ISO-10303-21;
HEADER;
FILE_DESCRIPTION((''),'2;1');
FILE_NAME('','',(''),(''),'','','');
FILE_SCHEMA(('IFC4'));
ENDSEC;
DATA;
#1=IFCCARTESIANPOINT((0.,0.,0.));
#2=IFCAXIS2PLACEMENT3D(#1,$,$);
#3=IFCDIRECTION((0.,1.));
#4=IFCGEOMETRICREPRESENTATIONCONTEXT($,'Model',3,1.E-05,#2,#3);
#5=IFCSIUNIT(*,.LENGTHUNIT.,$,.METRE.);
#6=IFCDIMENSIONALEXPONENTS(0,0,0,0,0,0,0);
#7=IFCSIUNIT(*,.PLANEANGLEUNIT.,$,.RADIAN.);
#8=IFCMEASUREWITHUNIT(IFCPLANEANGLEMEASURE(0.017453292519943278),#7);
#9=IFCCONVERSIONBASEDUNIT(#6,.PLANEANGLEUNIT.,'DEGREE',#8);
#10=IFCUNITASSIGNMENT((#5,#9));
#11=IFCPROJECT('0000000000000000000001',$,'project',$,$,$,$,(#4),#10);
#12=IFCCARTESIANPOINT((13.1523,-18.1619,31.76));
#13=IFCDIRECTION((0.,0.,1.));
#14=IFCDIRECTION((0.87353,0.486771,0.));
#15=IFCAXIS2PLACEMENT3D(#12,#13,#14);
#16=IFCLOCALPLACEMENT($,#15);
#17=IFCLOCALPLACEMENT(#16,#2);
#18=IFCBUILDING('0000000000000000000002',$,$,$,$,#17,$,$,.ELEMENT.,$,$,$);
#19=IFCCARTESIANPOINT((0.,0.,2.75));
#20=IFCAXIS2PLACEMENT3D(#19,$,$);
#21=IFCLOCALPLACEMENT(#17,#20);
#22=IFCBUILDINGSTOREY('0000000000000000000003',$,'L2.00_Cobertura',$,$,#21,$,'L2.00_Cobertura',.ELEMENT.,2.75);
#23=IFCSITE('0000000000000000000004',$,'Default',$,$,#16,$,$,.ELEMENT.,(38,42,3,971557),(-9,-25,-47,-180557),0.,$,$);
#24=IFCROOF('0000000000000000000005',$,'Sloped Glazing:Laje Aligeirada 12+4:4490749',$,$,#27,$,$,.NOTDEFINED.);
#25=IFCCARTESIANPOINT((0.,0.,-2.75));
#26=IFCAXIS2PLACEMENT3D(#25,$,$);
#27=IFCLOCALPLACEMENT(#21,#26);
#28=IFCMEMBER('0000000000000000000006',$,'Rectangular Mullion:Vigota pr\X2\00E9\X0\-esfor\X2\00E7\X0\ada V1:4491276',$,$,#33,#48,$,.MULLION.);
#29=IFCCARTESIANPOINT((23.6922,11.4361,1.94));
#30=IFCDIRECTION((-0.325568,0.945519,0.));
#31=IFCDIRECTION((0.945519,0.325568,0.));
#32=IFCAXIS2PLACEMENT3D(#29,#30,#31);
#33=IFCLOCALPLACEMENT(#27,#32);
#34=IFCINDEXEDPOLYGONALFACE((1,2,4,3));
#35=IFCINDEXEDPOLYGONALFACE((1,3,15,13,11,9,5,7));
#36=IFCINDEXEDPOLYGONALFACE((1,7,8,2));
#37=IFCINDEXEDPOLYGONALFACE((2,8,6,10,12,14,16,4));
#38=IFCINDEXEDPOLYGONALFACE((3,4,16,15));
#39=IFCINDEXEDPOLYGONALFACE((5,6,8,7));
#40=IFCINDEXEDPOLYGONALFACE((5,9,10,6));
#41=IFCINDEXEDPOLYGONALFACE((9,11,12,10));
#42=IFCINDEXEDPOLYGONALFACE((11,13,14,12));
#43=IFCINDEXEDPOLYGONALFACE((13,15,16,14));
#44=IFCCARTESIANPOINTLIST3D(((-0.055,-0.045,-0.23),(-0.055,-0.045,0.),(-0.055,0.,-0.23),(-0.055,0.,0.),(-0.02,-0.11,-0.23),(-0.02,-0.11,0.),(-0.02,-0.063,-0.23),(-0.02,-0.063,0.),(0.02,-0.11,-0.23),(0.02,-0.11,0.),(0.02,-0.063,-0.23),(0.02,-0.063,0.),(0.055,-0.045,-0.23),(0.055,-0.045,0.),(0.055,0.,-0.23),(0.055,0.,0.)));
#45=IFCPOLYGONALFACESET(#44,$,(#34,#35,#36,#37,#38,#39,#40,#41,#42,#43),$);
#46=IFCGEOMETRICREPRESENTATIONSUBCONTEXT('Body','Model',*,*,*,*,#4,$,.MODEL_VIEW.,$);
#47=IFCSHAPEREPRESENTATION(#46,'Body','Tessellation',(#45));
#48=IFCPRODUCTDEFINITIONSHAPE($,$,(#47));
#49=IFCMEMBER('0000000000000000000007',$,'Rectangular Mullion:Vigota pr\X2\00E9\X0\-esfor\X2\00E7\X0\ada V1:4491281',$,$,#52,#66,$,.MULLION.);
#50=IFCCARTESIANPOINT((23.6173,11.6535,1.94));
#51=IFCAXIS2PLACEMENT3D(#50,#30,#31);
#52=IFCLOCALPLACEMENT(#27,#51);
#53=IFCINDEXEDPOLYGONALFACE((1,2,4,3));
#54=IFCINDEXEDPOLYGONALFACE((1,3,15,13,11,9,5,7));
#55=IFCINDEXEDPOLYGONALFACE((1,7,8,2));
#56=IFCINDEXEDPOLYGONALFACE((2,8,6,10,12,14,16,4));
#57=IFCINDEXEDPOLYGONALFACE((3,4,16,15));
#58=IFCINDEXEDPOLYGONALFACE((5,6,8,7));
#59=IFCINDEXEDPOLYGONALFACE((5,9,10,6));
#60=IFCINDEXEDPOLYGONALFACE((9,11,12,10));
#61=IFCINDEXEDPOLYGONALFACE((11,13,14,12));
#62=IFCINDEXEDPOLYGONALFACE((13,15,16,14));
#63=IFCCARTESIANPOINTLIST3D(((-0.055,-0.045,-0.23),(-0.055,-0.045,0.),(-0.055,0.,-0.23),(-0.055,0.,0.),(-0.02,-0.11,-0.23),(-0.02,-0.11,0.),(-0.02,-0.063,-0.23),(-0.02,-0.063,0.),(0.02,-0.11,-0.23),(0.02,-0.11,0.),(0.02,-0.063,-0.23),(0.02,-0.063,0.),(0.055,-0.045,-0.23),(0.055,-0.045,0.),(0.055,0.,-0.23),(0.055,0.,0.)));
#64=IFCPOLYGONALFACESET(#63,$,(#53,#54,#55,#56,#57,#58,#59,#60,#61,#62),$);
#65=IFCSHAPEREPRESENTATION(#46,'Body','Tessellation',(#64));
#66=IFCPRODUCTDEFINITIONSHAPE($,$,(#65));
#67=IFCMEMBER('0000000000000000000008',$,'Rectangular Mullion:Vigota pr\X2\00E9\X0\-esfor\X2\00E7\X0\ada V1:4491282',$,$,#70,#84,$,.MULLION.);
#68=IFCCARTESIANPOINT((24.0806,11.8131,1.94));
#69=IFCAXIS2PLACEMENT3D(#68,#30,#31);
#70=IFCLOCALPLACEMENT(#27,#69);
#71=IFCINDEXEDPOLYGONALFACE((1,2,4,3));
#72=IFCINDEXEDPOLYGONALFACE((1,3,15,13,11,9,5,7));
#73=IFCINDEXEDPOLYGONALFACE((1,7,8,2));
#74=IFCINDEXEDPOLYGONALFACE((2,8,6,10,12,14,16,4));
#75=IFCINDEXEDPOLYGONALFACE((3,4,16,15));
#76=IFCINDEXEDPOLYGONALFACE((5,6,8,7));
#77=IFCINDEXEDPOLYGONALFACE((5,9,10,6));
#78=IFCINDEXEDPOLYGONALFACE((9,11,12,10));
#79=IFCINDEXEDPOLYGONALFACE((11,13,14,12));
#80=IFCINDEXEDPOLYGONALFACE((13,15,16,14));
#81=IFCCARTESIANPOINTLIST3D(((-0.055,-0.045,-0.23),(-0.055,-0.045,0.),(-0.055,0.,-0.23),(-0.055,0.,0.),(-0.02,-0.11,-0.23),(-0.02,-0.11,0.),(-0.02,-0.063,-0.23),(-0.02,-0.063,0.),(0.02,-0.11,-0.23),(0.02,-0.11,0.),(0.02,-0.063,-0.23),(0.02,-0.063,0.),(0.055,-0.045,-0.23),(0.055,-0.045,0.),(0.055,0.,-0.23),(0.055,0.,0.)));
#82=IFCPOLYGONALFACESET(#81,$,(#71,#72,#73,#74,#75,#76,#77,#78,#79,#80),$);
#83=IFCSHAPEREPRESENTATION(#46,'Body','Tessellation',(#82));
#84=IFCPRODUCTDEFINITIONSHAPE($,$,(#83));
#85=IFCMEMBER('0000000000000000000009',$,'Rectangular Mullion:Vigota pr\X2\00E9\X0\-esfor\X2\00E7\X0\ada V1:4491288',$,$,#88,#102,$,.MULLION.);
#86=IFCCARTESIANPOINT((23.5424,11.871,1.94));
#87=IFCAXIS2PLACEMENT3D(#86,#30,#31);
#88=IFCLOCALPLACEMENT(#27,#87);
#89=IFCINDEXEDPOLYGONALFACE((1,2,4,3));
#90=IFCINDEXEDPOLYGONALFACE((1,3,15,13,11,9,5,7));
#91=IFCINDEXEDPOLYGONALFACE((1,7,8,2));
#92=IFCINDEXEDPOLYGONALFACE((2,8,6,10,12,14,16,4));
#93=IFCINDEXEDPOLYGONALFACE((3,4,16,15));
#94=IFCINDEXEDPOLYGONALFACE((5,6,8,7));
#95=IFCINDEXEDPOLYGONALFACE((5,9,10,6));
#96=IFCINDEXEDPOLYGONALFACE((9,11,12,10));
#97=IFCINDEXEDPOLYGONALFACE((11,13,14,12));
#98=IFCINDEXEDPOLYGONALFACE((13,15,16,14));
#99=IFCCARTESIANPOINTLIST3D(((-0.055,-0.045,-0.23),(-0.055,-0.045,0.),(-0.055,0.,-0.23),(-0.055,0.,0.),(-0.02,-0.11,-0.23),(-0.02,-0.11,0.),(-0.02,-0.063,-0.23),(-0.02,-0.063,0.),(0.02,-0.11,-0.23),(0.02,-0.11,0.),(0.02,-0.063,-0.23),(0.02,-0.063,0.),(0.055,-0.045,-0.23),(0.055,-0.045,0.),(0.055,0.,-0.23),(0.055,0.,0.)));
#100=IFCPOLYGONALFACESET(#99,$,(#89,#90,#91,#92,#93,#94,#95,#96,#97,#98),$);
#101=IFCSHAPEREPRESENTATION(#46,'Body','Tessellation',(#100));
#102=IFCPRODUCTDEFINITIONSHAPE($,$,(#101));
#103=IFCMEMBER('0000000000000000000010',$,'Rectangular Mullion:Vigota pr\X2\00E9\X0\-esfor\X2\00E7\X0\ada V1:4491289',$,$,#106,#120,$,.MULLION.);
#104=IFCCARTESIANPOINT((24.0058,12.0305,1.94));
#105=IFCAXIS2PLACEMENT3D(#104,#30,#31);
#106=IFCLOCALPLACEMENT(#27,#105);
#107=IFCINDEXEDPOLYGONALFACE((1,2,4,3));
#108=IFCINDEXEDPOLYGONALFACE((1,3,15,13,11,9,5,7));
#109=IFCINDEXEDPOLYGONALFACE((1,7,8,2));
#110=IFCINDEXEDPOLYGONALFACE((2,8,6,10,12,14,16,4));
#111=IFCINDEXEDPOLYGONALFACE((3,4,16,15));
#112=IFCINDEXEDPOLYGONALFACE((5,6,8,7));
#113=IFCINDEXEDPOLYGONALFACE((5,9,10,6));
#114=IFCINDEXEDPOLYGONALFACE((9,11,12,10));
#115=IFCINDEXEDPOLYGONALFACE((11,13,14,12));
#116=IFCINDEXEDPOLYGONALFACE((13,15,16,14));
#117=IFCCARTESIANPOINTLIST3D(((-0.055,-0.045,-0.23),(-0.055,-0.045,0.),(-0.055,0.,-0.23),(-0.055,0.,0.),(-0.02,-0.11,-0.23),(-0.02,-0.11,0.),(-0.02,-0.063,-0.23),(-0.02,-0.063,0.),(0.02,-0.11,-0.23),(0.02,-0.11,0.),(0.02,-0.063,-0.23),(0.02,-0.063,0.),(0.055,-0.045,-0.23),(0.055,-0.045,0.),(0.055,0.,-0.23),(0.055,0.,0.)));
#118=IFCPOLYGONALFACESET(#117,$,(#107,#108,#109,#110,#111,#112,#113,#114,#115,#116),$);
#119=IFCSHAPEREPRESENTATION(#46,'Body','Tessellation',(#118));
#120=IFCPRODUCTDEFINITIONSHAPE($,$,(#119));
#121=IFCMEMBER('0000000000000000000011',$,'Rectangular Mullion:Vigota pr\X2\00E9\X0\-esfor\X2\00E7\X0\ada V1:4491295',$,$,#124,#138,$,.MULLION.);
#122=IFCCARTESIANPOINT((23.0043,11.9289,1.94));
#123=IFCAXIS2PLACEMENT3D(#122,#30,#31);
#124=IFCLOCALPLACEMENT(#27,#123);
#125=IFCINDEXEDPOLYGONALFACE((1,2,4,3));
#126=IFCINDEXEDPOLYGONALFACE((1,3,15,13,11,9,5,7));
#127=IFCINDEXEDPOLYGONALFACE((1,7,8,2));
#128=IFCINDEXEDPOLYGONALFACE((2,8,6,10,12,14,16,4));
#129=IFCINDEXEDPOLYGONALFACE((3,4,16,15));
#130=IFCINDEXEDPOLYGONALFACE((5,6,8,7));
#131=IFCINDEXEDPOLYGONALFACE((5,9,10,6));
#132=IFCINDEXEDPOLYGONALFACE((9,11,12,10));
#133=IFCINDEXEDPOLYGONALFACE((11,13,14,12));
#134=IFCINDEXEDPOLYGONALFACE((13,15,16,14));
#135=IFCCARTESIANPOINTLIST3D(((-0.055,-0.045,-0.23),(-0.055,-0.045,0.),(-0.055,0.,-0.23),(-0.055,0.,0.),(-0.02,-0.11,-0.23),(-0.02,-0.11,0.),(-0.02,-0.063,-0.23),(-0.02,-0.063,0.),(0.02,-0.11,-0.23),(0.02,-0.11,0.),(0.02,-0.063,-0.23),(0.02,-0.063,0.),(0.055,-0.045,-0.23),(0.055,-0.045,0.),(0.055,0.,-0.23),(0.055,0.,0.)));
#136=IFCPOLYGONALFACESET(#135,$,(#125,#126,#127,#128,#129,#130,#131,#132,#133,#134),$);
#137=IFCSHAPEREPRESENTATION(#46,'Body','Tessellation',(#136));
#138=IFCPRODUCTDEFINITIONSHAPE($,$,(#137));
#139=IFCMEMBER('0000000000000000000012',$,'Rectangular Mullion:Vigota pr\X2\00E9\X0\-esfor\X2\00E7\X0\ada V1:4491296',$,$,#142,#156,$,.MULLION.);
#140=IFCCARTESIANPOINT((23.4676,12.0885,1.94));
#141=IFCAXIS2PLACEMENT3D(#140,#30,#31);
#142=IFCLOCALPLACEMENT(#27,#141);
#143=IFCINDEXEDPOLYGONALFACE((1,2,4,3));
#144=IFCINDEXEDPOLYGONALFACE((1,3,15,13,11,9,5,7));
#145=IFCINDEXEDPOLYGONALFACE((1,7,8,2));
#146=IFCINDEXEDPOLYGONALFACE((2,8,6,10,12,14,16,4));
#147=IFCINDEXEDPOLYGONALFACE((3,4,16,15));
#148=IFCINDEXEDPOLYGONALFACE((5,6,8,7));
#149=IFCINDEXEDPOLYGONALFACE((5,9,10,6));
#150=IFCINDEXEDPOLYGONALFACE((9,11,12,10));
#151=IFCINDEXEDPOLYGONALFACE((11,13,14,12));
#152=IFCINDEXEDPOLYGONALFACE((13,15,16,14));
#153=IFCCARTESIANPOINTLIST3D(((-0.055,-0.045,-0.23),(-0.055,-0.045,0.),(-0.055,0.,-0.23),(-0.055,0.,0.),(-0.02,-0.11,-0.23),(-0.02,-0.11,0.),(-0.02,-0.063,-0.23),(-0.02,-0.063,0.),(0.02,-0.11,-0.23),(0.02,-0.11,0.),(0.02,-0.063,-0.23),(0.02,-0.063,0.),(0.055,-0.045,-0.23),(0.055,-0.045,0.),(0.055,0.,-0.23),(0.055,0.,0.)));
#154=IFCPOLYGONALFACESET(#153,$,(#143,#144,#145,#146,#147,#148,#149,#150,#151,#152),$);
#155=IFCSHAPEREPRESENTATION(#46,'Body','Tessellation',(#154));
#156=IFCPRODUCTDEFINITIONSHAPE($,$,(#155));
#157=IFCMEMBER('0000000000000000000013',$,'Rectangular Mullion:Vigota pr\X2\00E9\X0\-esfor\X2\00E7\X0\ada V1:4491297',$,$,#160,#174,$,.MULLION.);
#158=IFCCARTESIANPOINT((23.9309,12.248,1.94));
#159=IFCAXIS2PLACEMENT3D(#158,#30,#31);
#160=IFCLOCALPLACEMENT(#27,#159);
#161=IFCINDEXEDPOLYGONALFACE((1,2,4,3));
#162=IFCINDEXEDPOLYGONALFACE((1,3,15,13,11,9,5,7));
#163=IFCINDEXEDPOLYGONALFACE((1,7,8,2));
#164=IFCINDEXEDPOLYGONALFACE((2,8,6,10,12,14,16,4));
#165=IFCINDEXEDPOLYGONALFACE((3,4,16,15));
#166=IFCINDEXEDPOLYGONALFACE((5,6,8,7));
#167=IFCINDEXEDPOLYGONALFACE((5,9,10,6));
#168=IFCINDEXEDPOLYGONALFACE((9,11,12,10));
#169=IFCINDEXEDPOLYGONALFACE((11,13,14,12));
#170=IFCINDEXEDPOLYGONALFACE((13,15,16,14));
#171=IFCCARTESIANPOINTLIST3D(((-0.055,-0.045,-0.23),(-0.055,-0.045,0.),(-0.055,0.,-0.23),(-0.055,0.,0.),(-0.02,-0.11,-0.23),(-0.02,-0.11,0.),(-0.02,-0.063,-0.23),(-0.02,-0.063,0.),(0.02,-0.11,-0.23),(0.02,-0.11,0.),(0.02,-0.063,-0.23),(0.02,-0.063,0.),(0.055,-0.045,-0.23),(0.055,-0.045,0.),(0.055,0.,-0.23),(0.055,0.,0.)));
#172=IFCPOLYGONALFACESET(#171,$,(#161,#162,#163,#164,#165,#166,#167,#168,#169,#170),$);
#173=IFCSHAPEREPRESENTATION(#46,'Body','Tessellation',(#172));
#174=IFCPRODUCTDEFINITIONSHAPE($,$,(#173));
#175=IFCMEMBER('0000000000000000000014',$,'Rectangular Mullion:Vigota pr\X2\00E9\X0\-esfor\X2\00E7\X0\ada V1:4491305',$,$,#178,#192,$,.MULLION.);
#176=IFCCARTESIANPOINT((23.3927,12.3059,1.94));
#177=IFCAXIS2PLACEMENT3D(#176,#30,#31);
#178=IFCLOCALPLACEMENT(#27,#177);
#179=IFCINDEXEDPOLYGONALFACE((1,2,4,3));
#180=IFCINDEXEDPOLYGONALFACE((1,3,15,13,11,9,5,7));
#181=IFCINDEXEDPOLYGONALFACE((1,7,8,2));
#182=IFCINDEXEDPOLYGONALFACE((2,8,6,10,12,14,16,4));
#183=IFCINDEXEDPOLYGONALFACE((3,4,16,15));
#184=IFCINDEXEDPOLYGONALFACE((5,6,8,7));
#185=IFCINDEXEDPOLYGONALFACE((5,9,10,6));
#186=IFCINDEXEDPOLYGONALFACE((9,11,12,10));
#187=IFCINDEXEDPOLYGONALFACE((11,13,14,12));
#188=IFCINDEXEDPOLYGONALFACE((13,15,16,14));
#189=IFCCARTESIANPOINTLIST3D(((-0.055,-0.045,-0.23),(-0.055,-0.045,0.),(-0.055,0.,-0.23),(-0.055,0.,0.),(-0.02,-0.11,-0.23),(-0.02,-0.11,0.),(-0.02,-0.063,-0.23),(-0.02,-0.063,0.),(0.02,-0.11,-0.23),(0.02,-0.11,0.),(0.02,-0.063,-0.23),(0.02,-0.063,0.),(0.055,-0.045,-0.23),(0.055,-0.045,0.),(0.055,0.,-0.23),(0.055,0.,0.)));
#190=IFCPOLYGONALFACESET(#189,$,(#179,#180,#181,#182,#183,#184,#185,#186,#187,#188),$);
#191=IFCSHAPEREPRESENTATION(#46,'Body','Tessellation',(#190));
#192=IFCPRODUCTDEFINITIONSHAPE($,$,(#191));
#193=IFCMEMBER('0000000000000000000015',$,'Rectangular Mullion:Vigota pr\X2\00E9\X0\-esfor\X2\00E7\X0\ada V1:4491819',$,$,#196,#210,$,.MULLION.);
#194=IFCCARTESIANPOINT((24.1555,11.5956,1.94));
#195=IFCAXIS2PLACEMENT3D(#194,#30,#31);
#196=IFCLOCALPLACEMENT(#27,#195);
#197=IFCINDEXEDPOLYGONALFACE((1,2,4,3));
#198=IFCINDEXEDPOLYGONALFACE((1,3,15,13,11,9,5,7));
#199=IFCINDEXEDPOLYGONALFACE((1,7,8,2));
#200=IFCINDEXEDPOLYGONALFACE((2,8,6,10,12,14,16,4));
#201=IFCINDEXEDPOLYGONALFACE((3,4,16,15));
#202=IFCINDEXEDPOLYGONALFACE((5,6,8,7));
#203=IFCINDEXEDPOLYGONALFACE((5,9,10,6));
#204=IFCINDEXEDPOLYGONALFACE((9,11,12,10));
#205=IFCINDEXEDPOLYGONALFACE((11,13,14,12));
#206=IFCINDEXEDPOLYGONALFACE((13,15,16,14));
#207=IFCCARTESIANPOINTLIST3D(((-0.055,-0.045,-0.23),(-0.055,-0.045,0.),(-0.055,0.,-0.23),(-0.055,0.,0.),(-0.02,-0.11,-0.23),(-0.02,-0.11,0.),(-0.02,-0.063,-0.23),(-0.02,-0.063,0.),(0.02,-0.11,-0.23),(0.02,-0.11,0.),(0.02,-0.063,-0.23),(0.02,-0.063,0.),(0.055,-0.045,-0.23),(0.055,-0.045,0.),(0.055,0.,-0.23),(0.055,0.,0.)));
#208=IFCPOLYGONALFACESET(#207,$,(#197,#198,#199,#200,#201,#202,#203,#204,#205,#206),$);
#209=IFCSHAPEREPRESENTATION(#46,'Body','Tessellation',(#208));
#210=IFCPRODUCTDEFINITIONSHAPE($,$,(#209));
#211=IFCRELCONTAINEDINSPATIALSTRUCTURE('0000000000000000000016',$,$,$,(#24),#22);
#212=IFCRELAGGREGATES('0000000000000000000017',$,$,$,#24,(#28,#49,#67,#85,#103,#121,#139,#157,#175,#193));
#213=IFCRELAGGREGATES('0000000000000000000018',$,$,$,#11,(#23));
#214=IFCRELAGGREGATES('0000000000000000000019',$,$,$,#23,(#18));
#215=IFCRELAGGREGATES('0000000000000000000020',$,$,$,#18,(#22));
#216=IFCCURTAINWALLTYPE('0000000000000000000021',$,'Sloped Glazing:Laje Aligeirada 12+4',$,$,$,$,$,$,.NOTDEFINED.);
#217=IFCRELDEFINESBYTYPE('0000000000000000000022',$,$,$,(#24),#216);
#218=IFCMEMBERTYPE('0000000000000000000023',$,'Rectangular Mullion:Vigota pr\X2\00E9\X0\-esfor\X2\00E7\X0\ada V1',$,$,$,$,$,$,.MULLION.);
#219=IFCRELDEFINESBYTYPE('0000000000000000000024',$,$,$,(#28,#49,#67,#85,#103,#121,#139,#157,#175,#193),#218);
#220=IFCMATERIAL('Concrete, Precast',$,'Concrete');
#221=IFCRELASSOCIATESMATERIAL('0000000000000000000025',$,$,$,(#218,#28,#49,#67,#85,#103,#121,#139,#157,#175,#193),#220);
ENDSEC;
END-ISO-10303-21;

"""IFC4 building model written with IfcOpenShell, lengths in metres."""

from ifc_helpers import new_model, entity, si_unit, converted_unit, direction, frame, origin, place, context, subcontext, project, spatial, indexed_curve, outline, extrude, source, transform, mapped, material, type_object, type_shapes, element, aggregate, save


model = new_model("IFC4")

# Units and contexts
model_context = context("Model", 3, precision=1e-05, world=origin(), true_north=direction((0.0, 1.0)))
body_context = subcontext(model_context, "Body", "Model", "MODEL_VIEW")
ifc_project = project(units=[si_unit("LENGTHUNIT", "METRE"), converted_unit("PLANEANGLEUNIT", "DEGREE", entity("IfcPlaneAngleMeasure", 0.017453292519943278), si_unit("PLANEANGLEUNIT", "RADIAN"), dimensions=[0, 0, 0, 0, 0, 0, 0])], contexts=[model_context])

# Site, building, storey
site_placement = place(None, frame((13.1523, -18.1619, 31.76), z_axis=(0.0, 0.0, 1.0), x_axis=(0.87353, 0.486771, 0.0)))
site = spatial("IfcSite", under=ifc_project, at=site_placement, Name="Default", CompositionType="ELEMENT", RefLatitude=(38, 42, 3, 971557), RefLongitude=(-9, -25, -47, -180557), RefElevation=0.0)
building_placement = place(site_placement, origin())
building = spatial("IfcBuilding", under=site, at=building_placement, CompositionType="ELEMENT")
storey_placement = place(building_placement, frame((0.0, 0.0, 2.75)))
storey = spatial("IfcBuildingStorey", under=building, at=storey_placement, Name="L2.00_Cobertura", LongName="L2.00_Cobertura", CompositionType="ELEMENT", Elevation=2.75)

# Roof, members
curtain_wall_type = type_object("IfcCurtainWallType", Name="Sloped Glazing:Laje Aligeirada 12+4", PredefinedType="NOTDEFINED")
roof_placement = place(storey_placement, frame((0.0, 0.0, -2.75)))
roof = element("IfcRoof", 1, at=roof_placement, inside=storey, type_object=curtain_wall_type, Name="Sloped Glazing:Laje Aligeirada 12+4:4490749", PredefinedType="NOTDEFINED")
ifc_material_1 = material(Name="Concrete, Precast", Category="Concrete")
member_type_1 = type_object("IfcMemberType", Name="Rectangular Mullion:Vigota pré-esforçada V1", PredefinedType="MULLION", material=ifc_material_1)
shared_shape_1 = source(origin(), body_context, "Body", "SweptSolid", [
    extrude(outline(indexed_curve([(-0.055, -0.0545), (0.055, -0.0545), (0.055, -0.0095), (0.02, 0.0085), (0.02, 0.0555), (-0.02, 0.0555), (-0.02, 0.0085), (-0.055, -0.0095), (-0.055, -0.0545)], self_intersect=False)), frame((0.0, -0.0545, -0.23), z_axis=(0.0, 0.0, 1.0), x_axis=(-1.0, 0.0, 0.0)), (0.0, 0.0, 1.0), 0.23),
])
type_shapes(member_type_1, [shared_shape_1])
member_1_placement = place(roof_placement, frame((23.6922, 11.4361, 1.94), z_axis=(-0.325568, 0.945519, 0.0), x_axis=(0.945519, 0.325568, 0.0)))
member_1 = element("IfcMember", 2, at=member_1_placement, type_object=member_type_1, material=ifc_material_1, Name="Rectangular Mullion:Vigota pré-esforçada V1:4491276", PredefinedType="MULLION", context=body_context, shape_type="MappedRepresentation", body=[
    mapped(shared_shape_1, transform((0.0, 0.0, 0.0), scale=1.0)),
])
member_2_placement = place(roof_placement, frame((23.6173, 11.6535, 1.94), z_axis=(-0.325568, 0.945519, 0.0), x_axis=(0.945519, 0.325568, 0.0)))
member_2 = element("IfcMember", 3, at=member_2_placement, type_object=member_type_1, material=ifc_material_1, Name="Rectangular Mullion:Vigota pré-esforçada V1:4491281", PredefinedType="MULLION", context=body_context, shape_type="MappedRepresentation", body=[
    mapped(shared_shape_1, transform((0.0, 0.0, 0.0), scale=1.0)),
])
member_3_placement = place(roof_placement, frame((24.0806, 11.8131, 1.94), z_axis=(-0.325568, 0.945519, 0.0), x_axis=(0.945519, 0.325568, 0.0)))
member_3 = element("IfcMember", 4, at=member_3_placement, type_object=member_type_1, material=ifc_material_1, Name="Rectangular Mullion:Vigota pré-esforçada V1:4491282", PredefinedType="MULLION", context=body_context, shape_type="MappedRepresentation", body=[
    mapped(shared_shape_1, transform((0.0, 0.0, 0.0), scale=1.0)),
])
member_4_placement = place(roof_placement, frame((23.5424, 11.871, 1.94), z_axis=(-0.325568, 0.945519, 0.0), x_axis=(0.945519, 0.325568, 0.0)))
member_4 = element("IfcMember", 5, at=member_4_placement, type_object=member_type_1, material=ifc_material_1, Name="Rectangular Mullion:Vigota pré-esforçada V1:4491288", PredefinedType="MULLION", context=body_context, shape_type="MappedRepresentation", body=[
    mapped(shared_shape_1, transform((0.0, 0.0, 0.0), scale=1.0)),
])
member_5_placement = place(roof_placement, frame((24.0058, 12.0305, 1.94), z_axis=(-0.325568, 0.945519, 0.0), x_axis=(0.945519, 0.325568, 0.0)))
member_5 = element("IfcMember", 6, at=member_5_placement, type_object=member_type_1, material=ifc_material_1, Name="Rectangular Mullion:Vigota pré-esforçada V1:4491289", PredefinedType="MULLION", context=body_context, shape_type="MappedRepresentation", body=[
    mapped(shared_shape_1, transform((0.0, 0.0, 0.0), scale=1.0)),
])
member_6_placement = place(roof_placement, frame((23.0043, 11.9289, 1.94), z_axis=(-0.325568, 0.945519, 0.0), x_axis=(0.945519, 0.325568, 0.0)))
member_6 = element("IfcMember", 7, at=member_6_placement, type_object=member_type_1, material=ifc_material_1, Name="Rectangular Mullion:Vigota pré-esforçada V1:4491295", PredefinedType="MULLION", context=body_context, shape_type="MappedRepresentation", body=[
    mapped(shared_shape_1, transform((0.0, 0.0, 0.0), scale=1.0)),
])
member_7_placement = place(roof_placement, frame((23.4676, 12.0885, 1.94), z_axis=(-0.325568, 0.945519, 0.0), x_axis=(0.945519, 0.325568, 0.0)))
member_7 = element("IfcMember", 8, at=member_7_placement, type_object=member_type_1, material=ifc_material_1, Name="Rectangular Mullion:Vigota pré-esforçada V1:4491296", PredefinedType="MULLION", context=body_context, shape_type="MappedRepresentation", body=[
    mapped(shared_shape_1, transform((0.0, 0.0, 0.0), scale=1.0)),
])
member_8_placement = place(roof_placement, frame((23.9309, 12.248, 1.94), z_axis=(-0.325568, 0.945519, 0.0), x_axis=(0.945519, 0.325568, 0.0)))
member_8 = element("IfcMember", 9, at=member_8_placement, type_object=member_type_1, material=ifc_material_1, Name="Rectangular Mullion:Vigota pré-esforçada V1:4491297", PredefinedType="MULLION", context=body_context, shape_type="MappedRepresentation", body=[
    mapped(shared_shape_1, transform((0.0, 0.0, 0.0), scale=1.0)),
])
member_9_placement = place(roof_placement, frame((23.3927, 12.3059, 1.94), z_axis=(-0.325568, 0.945519, 0.0), x_axis=(0.945519, 0.325568, 0.0)))
member_9 = element("IfcMember", 10, at=member_9_placement, type_object=member_type_1, material=ifc_material_1, Name="Rectangular Mullion:Vigota pré-esforçada V1:4491305", PredefinedType="MULLION", context=body_context, shape_type="MappedRepresentation", body=[
    mapped(shared_shape_1, transform((0.0, 0.0, 0.0), scale=1.0)),
])
member_10_placement = place(roof_placement, frame((24.1555, 11.5956, 1.94), z_axis=(-0.325568, 0.945519, 0.0), x_axis=(0.945519, 0.325568, 0.0)))
member_10 = element("IfcMember", 11, at=member_10_placement, type_object=member_type_1, material=ifc_material_1, Name="Rectangular Mullion:Vigota pré-esforçada V1:4491819", PredefinedType="MULLION", context=body_context, shape_type="MappedRepresentation", body=[
    mapped(shared_shape_1, transform((0.0, 0.0, 0.0), scale=1.0)),
])
aggregate(roof, [member_1, member_2, member_3, member_4, member_5, member_6, member_7, member_8, member_9, member_10])

save(model, "model.ifc")
